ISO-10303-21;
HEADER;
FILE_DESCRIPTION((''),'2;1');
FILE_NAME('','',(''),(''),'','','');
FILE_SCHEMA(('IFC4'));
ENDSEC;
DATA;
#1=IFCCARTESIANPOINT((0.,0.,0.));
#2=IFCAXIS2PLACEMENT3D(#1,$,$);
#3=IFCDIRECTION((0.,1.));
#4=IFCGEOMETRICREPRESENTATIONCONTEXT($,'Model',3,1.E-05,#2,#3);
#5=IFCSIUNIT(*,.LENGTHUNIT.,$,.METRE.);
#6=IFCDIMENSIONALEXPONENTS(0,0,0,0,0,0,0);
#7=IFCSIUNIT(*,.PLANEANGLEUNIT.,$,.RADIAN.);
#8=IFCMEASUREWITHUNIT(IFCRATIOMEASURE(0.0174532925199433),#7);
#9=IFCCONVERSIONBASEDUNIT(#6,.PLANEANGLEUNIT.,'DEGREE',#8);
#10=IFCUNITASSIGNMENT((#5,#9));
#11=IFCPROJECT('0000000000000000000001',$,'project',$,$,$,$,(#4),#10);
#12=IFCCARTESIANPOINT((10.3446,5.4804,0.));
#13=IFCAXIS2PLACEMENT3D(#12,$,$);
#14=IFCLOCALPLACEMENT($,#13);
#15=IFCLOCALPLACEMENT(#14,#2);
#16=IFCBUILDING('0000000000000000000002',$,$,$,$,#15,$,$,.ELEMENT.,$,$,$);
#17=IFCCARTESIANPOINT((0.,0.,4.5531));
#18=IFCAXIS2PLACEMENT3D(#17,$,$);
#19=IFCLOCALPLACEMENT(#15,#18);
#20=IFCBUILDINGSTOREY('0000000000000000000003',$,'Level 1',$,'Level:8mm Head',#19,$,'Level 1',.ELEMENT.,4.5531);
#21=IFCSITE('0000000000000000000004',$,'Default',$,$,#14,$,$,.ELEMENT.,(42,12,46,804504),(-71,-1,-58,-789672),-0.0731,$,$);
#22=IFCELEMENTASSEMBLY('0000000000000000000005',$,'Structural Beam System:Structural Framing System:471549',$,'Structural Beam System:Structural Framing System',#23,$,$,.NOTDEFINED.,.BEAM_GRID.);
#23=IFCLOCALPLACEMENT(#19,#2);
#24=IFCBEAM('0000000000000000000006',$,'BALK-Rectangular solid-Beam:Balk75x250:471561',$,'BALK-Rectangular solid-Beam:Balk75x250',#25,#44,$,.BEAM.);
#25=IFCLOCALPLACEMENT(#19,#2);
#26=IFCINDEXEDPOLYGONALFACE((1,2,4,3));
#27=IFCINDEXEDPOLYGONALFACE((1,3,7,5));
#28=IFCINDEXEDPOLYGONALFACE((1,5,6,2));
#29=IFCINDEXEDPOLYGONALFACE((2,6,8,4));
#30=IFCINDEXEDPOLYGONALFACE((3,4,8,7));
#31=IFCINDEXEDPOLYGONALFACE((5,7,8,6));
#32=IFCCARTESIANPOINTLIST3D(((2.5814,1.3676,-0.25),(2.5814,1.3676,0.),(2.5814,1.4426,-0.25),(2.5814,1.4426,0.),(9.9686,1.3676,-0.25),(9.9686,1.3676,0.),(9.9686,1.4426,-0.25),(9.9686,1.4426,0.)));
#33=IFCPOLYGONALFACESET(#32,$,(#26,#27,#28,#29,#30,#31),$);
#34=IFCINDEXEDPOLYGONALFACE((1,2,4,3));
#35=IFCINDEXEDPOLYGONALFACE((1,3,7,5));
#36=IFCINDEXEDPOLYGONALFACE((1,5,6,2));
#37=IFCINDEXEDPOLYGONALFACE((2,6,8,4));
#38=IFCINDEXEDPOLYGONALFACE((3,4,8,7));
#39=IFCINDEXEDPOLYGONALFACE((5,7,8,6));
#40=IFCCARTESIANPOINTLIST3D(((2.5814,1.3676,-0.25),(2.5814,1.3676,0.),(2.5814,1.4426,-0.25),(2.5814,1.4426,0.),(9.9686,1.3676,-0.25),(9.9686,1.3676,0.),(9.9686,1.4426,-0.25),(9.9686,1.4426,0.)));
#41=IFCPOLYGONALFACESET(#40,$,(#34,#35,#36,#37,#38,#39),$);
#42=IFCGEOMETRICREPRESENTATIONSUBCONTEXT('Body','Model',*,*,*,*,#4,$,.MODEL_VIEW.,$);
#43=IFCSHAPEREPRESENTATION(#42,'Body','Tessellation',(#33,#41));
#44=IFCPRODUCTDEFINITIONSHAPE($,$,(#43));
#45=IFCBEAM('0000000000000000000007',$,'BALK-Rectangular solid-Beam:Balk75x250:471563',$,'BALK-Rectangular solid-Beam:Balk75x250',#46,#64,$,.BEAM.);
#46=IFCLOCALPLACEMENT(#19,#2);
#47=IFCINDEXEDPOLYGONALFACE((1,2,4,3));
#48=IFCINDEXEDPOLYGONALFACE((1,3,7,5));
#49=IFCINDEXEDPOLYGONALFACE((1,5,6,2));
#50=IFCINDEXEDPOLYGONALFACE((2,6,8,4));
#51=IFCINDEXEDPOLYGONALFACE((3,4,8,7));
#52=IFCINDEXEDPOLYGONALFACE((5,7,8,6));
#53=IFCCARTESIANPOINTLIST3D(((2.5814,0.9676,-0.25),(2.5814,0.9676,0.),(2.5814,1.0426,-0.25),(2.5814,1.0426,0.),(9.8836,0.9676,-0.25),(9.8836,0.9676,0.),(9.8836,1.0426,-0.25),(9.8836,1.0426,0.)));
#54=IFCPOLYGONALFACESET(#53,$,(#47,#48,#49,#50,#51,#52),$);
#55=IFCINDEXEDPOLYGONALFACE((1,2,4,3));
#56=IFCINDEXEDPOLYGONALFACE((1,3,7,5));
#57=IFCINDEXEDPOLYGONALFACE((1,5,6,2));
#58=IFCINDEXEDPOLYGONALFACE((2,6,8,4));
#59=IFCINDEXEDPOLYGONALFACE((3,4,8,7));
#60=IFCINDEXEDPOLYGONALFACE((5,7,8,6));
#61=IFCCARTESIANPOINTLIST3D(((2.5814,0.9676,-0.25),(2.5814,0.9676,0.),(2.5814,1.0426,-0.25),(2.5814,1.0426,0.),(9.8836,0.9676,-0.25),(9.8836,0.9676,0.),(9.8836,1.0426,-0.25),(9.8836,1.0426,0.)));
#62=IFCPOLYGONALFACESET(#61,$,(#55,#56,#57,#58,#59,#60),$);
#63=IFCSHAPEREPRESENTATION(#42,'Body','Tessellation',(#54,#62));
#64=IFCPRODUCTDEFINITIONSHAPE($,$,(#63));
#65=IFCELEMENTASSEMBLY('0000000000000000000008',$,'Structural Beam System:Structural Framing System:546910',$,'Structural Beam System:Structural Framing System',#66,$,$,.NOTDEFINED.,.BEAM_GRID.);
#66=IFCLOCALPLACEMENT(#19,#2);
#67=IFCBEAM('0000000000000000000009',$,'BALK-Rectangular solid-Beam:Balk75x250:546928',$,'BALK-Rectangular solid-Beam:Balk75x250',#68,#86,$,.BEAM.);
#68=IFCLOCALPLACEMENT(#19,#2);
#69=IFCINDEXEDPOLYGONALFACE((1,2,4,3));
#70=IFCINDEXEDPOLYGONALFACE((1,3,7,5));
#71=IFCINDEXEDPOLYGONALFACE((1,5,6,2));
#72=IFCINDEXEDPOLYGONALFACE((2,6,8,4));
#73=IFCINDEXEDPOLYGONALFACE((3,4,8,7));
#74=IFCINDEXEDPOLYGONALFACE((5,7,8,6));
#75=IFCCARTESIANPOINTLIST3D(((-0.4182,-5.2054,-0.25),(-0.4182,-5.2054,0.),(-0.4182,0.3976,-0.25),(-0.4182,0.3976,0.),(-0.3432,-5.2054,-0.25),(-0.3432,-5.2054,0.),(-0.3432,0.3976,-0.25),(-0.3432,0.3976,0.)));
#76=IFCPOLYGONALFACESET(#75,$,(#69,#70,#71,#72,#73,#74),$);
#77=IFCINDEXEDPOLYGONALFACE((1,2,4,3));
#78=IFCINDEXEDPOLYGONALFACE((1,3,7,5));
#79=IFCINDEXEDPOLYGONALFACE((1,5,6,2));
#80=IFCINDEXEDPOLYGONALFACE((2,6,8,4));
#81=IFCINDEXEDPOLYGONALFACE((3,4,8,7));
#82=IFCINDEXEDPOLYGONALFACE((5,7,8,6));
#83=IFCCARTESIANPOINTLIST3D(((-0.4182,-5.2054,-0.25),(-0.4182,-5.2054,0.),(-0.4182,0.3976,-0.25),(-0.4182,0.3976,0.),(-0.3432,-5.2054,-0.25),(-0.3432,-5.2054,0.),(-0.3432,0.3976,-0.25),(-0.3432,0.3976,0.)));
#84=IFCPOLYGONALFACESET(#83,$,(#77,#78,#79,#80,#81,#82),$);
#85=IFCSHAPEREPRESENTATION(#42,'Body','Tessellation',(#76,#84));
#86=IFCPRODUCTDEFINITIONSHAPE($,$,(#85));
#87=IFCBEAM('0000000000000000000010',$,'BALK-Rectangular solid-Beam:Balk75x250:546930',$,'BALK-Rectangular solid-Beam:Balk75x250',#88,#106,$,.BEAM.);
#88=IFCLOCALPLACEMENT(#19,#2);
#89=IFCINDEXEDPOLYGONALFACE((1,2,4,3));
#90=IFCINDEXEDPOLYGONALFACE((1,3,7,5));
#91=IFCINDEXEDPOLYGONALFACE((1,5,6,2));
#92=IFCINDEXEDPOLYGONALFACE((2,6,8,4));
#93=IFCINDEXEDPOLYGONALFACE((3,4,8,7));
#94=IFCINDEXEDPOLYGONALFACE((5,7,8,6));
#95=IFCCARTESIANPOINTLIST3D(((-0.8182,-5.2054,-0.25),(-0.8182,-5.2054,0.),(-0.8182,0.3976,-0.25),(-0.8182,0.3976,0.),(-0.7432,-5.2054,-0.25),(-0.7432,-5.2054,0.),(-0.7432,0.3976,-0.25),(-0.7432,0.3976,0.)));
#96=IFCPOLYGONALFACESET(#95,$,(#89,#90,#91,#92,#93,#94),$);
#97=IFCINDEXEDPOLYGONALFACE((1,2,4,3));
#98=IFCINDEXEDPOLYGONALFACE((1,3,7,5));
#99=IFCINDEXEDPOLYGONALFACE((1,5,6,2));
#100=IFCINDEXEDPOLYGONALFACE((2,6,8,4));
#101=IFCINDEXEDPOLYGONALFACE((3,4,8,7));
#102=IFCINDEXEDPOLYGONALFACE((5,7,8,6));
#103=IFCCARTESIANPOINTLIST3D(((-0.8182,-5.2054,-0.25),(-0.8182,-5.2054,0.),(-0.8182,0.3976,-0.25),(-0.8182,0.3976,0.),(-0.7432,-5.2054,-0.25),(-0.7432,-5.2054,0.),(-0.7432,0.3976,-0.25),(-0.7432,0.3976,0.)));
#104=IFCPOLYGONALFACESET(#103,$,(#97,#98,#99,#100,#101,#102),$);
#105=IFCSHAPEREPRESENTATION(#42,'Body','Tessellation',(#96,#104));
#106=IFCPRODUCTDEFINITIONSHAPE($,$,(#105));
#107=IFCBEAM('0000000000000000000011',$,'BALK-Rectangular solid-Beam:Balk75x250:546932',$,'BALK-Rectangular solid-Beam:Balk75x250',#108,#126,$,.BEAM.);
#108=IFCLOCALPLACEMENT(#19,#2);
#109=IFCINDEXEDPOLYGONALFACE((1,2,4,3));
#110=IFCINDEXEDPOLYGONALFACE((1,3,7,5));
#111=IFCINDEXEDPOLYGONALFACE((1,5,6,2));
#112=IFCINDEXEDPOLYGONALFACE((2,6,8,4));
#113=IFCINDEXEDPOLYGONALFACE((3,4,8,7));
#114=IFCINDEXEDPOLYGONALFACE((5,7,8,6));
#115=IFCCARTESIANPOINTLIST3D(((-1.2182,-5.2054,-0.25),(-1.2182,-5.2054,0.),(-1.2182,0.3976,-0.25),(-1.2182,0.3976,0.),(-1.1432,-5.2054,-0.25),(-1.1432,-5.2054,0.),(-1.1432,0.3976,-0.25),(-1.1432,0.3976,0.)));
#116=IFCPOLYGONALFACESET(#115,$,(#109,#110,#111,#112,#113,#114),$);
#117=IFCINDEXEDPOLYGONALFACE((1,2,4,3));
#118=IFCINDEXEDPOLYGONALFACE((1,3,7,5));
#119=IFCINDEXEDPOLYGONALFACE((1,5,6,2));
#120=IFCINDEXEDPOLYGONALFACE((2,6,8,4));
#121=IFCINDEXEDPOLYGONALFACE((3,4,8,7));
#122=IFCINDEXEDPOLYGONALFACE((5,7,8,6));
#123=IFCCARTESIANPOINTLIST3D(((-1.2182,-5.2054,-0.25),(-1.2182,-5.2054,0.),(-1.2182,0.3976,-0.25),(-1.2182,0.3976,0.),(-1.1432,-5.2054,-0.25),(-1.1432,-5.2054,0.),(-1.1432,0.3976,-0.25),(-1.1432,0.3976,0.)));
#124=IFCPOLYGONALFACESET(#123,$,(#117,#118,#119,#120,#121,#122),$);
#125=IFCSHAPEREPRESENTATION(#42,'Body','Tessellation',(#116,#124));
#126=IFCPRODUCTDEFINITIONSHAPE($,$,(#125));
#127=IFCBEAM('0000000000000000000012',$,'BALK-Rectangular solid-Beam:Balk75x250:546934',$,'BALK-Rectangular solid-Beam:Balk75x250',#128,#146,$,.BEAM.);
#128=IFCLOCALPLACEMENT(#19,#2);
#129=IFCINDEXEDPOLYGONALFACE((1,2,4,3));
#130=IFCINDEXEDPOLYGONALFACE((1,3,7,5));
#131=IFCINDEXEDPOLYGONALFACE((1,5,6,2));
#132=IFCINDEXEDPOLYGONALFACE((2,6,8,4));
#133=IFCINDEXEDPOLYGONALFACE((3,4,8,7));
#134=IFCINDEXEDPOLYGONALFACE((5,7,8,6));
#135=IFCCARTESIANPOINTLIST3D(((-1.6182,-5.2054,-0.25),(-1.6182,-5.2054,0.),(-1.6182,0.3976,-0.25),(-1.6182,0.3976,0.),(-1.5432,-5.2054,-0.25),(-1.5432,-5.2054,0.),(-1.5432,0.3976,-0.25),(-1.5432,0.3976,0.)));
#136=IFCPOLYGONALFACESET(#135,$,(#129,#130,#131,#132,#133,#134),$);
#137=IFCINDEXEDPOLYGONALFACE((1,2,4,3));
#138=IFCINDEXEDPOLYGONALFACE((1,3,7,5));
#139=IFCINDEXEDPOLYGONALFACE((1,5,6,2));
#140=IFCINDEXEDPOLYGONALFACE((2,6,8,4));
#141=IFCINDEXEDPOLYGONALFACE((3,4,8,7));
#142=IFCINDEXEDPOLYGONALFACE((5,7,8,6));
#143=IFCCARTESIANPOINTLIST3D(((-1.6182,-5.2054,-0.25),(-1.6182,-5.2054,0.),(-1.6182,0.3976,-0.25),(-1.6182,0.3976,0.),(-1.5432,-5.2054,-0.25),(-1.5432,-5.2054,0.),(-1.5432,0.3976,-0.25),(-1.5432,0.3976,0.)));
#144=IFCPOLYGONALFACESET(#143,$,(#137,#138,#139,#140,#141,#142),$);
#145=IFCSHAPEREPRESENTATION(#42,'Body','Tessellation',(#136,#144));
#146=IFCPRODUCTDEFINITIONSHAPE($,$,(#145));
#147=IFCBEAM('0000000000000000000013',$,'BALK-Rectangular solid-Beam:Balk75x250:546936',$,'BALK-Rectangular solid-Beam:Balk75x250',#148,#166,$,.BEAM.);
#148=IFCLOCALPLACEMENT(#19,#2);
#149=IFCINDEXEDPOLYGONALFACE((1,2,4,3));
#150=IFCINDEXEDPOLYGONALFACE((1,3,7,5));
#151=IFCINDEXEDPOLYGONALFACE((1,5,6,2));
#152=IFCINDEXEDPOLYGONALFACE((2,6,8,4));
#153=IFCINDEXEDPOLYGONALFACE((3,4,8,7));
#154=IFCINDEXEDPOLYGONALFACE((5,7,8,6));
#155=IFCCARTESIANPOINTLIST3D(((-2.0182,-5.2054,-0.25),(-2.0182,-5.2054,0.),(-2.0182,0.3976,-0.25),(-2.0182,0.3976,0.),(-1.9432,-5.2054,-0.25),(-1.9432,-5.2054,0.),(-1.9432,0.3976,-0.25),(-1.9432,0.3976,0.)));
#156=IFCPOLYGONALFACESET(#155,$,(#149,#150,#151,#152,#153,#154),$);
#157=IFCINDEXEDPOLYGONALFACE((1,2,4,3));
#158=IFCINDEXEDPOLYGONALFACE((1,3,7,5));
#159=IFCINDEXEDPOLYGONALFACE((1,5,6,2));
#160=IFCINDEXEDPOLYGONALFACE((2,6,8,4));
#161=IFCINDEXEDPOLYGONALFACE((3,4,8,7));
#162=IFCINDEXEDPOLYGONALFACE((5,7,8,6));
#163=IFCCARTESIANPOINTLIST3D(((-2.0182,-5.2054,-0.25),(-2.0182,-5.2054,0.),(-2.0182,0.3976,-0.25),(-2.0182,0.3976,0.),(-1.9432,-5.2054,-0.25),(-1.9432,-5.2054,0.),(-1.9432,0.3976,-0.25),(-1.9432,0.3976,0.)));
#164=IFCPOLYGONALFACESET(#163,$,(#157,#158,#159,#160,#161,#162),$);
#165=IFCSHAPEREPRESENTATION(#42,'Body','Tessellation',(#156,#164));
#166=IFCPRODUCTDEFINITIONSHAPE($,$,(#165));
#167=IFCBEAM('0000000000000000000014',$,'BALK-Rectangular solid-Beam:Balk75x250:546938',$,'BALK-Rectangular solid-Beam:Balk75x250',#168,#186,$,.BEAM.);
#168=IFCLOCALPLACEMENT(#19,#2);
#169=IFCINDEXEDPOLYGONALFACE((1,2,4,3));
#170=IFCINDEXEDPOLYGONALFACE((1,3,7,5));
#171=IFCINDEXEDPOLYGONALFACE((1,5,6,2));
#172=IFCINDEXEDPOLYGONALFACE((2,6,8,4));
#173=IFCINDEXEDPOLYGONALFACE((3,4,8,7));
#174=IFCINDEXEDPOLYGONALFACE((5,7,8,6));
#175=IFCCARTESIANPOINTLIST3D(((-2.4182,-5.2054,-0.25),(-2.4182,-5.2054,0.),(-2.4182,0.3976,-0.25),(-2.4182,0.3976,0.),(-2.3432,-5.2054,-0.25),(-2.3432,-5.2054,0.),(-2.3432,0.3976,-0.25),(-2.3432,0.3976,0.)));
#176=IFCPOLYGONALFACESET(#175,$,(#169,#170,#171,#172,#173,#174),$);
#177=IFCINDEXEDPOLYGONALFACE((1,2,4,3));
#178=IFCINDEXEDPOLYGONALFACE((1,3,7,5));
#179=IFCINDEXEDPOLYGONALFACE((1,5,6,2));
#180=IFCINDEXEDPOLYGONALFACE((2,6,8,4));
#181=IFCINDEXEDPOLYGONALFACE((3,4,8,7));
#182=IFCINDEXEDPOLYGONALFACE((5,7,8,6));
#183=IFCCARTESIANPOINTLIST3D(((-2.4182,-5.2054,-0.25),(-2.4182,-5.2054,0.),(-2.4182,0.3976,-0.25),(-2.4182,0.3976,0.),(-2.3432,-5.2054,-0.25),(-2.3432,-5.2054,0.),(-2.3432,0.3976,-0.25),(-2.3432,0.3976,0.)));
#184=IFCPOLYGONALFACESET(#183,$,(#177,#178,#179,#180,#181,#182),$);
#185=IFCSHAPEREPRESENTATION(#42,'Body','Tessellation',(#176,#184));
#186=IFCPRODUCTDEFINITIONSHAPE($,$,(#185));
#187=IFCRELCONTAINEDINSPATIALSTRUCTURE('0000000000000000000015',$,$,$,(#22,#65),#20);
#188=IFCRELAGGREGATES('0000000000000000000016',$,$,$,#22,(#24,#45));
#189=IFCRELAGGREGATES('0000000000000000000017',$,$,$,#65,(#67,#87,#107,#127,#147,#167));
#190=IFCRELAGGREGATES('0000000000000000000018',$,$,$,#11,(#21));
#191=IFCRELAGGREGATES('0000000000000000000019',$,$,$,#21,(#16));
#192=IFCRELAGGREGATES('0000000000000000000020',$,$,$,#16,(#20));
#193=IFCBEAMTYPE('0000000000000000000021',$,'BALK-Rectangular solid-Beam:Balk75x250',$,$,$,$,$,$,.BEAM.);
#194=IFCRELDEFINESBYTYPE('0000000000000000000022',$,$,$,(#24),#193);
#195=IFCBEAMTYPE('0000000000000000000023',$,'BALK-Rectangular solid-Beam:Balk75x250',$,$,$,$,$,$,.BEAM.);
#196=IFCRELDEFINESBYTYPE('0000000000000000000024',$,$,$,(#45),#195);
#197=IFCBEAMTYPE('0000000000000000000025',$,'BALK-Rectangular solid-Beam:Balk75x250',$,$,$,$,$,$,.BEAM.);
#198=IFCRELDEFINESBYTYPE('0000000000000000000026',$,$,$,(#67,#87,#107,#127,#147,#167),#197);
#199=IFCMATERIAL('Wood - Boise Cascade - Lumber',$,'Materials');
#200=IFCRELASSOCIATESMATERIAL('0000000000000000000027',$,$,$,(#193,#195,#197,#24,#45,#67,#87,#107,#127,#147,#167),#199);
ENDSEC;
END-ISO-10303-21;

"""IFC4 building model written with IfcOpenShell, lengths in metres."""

from ifc_helpers import new_model, entity, si_unit, converted_unit, direction, frame, frame_2d, origin, origin_2d_with_axis, place, context, subcontext, project, spatial, rectangle, extrude, source, transform, mapped, material, material_profile, profile_set, profile_usage, type_object, type_shapes, element, aggregate, save


model = new_model("IFC4")

# Units and contexts
model_context = context("Model", 3, precision=1e-05, world=origin(), true_north=direction((0.0, 1.0)))
body_context = subcontext(model_context, "Body", "Model", "MODEL_VIEW")
ifc_project = project(units=[si_unit("LENGTHUNIT", "METRE"), converted_unit("PLANEANGLEUNIT", "DEGREE", entity("IfcRatioMeasure", 0.0174532925199433), si_unit("PLANEANGLEUNIT", "RADIAN"), dimensions=[0, 0, 0, 0, 0, 0, 0])], contexts=[model_context])

# Site, building, storey
site_placement = place(None, frame((10.3446, 5.4804, 0.0)))
site = spatial("IfcSite", under=ifc_project, at=site_placement, Name="Default", CompositionType="ELEMENT", RefLatitude=(42, 12, 46, 804504), RefLongitude=(-71, -1, -58, -789672), RefElevation=-0.0731)
building_placement = place(site_placement, origin())
building = spatial("IfcBuilding", under=site, at=building_placement, CompositionType="ELEMENT")
storey_placement = place(building_placement, frame((0.0, 0.0, 4.5531)))
storey = spatial("IfcBuildingStorey", under=building, at=storey_placement, Name="Level 1", ObjectType="Level:8mm Head", LongName="Level 1", CompositionType="ELEMENT", Elevation=4.5531)

# Element assemblies, beams
ifc_material = material(Name="Wood - Boise Cascade - Lumber", Category="Materials")
ifc_material_profile = material_profile(ifc_material, rectangle(XDim=0.25, YDim=0.075, at=frame_2d((0.0, 0.0), x_axis=(1.0, 0.0))), Name="Balk75x250")
ifc_profile_set = profile_set([ifc_material_profile], Name="Balk75x250")
assembly_1_placement = place(storey_placement, origin())
assembly_1 = element("IfcElementAssembly", 1, at=assembly_1_placement, inside=storey, Name="Structural Beam System:Structural Framing System:471549", ObjectType="Structural Beam System:Structural Framing System", AssemblyPlace="NOTDEFINED", PredefinedType="BEAM_GRID")
ifc_profile_usage_1 = profile_usage(ifc_profile_set, cardinal=8)
beam_type_1 = type_object("IfcBeamType", Name="BALK-Rectangular solid-Beam:Balk75x250", PredefinedType="BEAM", material=ifc_profile_set)
shared_shape_1 = source(origin(), body_context, "Body", "SweptSolid", [
    extrude(rectangle(XDim=0.25, YDim=0.075, at=frame_2d((0.0, 0.0), x_axis=(1.0, 0.0))), frame((2.5814, 1.4051, 4.4281), z_axis=(1.0, 0.0, 0.0), x_axis=(0.0, 0.0, -1.0)), (0.0, 0.0, 1.0), 7.3872),
    extrude(rectangle(XDim=0.25, YDim=0.075, at=frame_2d((0.0, 0.0), x_axis=(1.0, 0.0))), frame((2.5814, 1.4051, 4.4281), z_axis=(1.0, 0.0, 0.0), x_axis=(0.0, 0.0, -1.0)), (0.0, 0.0, 1.0), 7.3872),
])
type_shapes(beam_type_1, [shared_shape_1])
beam_1_placement = place(assembly_1_placement, frame((0.0, 0.0, -4.5531)))
beam_1 = element("IfcBeam", 2, at=beam_1_placement, type_object=beam_type_1, material=ifc_profile_usage_1, Name="BALK-Rectangular solid-Beam:Balk75x250:471561", ObjectType="BALK-Rectangular solid-Beam:Balk75x250", PredefinedType="BEAM", context=body_context, shape_type="MappedRepresentation", body=[
    mapped(shared_shape_1, transform((0.0, 0.0, 0.0), scale=1.0)),
])
ifc_profile_usage_2 = profile_usage(ifc_profile_set, cardinal=8)
beam_type_2 = type_object("IfcBeamType", Name="BALK-Rectangular solid-Beam:Balk75x250", PredefinedType="BEAM", material=ifc_profile_set)
shared_shape_2 = source(origin(), body_context, "Body", "SweptSolid", [
    extrude(rectangle(XDim=0.25, YDim=0.075, at=frame_2d((0.0, 0.0), x_axis=(1.0, 0.0))), frame((2.5814, 1.0051, 4.4281), z_axis=(1.0, 0.0, 0.0), x_axis=(0.0, 0.0, -1.0)), (0.0, 0.0, 1.0), 7.3022),
    extrude(rectangle(XDim=0.25, YDim=0.075, at=frame_2d((0.0, 0.0), x_axis=(1.0, 0.0))), frame((2.5814, 1.0051, 4.4281), z_axis=(1.0, 0.0, 0.0), x_axis=(0.0, 0.0, -1.0)), (0.0, 0.0, 1.0), 7.3022),
])
type_shapes(beam_type_2, [shared_shape_2])
beam_2_placement = place(assembly_1_placement, frame((0.0, 0.0, -4.5531)))
beam_2 = element("IfcBeam", 3, at=beam_2_placement, type_object=beam_type_2, material=ifc_profile_usage_2, Name="BALK-Rectangular solid-Beam:Balk75x250:471563", ObjectType="BALK-Rectangular solid-Beam:Balk75x250", PredefinedType="BEAM", context=body_context, shape_type="MappedRepresentation", body=[
    mapped(shared_shape_2, transform((0.0, 0.0, 0.0), scale=1.0)),
])
aggregate(assembly_1, [beam_1, beam_2])
assembly_2_placement = place(storey_placement, origin())
assembly_2 = element("IfcElementAssembly", 4, at=assembly_2_placement, inside=storey, Name="Structural Beam System:Structural Framing System:546910", ObjectType="Structural Beam System:Structural Framing System", AssemblyPlace="NOTDEFINED", PredefinedType="BEAM_GRID")
ifc_profile_usage_3 = profile_usage(ifc_profile_set, cardinal=8)
beam_type_3 = type_object("IfcBeamType", Name="BALK-Rectangular solid-Beam:Balk75x250", PredefinedType="BEAM", material=ifc_profile_set)
shared_shape_3 = source(origin(), body_context, "Body", "SweptSolid", [
    extrude(rectangle(XDim=0.25, YDim=0.075, at=origin_2d_with_axis()), frame((-2.9078, 0.0, 0.0), z_axis=(1.0, 0.0, 0.0), x_axis=(0.0, 0.0, -1.0)), (0.0, 0.0, 1.0), 5.603),
    extrude(rectangle(XDim=0.25, YDim=0.075, at=origin_2d_with_axis()), frame((-2.9078, 0.0, 0.0), z_axis=(1.0, 0.0, 0.0), x_axis=(0.0, 0.0, -1.0)), (0.0, 0.0, 1.0), 5.603),
])
type_shapes(beam_type_3, [shared_shape_3])
beam_3_placement = place(assembly_2_placement, frame((-0.3807, -2.5102, -0.125), z_axis=(0.0, 0.0, 1.0), x_axis=(0.0, -1.0, 0.0)))
beam_3 = element("IfcBeam", 5, at=beam_3_placement, type_object=beam_type_3, material=ifc_profile_usage_3, Name="BALK-Rectangular solid-Beam:Balk75x250:546928", ObjectType="BALK-Rectangular solid-Beam:Balk75x250", PredefinedType="BEAM", context=body_context, shape_type="MappedRepresentation", body=[
    mapped(shared_shape_3, transform((0.0, 0.0, 0.0), scale=1.0)),
])
ifc_profile_usage_4 = profile_usage(ifc_profile_set, cardinal=8)
beam_4_placement = place(assembly_2_placement, frame((-0.7807, -2.5102, -0.125), z_axis=(0.0, 0.0, 1.0), x_axis=(0.0, -1.0, 0.0)))
beam_4 = element("IfcBeam", 6, at=beam_4_placement, type_object=beam_type_3, material=ifc_profile_usage_4, Name="BALK-Rectangular solid-Beam:Balk75x250:546930", ObjectType="BALK-Rectangular solid-Beam:Balk75x250", PredefinedType="BEAM", context=body_context, shape_type="MappedRepresentation", body=[
    mapped(shared_shape_3, transform((0.0, 0.0, 0.0), scale=1.0)),
])
ifc_profile_usage_5 = profile_usage(ifc_profile_set, cardinal=8)
beam_5_placement = place(assembly_2_placement, frame((-1.1807, -2.5102, -0.125), z_axis=(0.0, 0.0, 1.0), x_axis=(0.0, -1.0, 0.0)))
beam_5 = element("IfcBeam", 7, at=beam_5_placement, type_object=beam_type_3, material=ifc_profile_usage_5, Name="BALK-Rectangular solid-Beam:Balk75x250:546932", ObjectType="BALK-Rectangular solid-Beam:Balk75x250", PredefinedType="BEAM", context=body_context, shape_type="MappedRepresentation", body=[
    mapped(shared_shape_3, transform((0.0, 0.0, 0.0), scale=1.0)),
])
ifc_profile_usage_6 = profile_usage(ifc_profile_set, cardinal=8)
beam_6_placement = place(assembly_2_placement, frame((-1.5807, -2.5102, -0.125), z_axis=(0.0, 0.0, 1.0), x_axis=(0.0, -1.0, 0.0)))
beam_6 = element("IfcBeam", 8, at=beam_6_placement, type_object=beam_type_3, material=ifc_profile_usage_6, Name="BALK-Rectangular solid-Beam:Balk75x250:546934", ObjectType="BALK-Rectangular solid-Beam:Balk75x250", PredefinedType="BEAM", context=body_context, shape_type="MappedRepresentation", body=[
    mapped(shared_shape_3, transform((0.0, 0.0, 0.0), scale=1.0)),
])
ifc_profile_usage_7 = profile_usage(ifc_profile_set, cardinal=8)
beam_7_placement = place(assembly_2_placement, frame((-1.9807, -2.5102, -0.125), z_axis=(0.0, 0.0, 1.0), x_axis=(0.0, -1.0, 0.0)))
beam_7 = element("IfcBeam", 9, at=beam_7_placement, type_object=beam_type_3, material=ifc_profile_usage_7, Name="BALK-Rectangular solid-Beam:Balk75x250:546936", ObjectType="BALK-Rectangular solid-Beam:Balk75x250", PredefinedType="BEAM", context=body_context, shape_type="MappedRepresentation", body=[
    mapped(shared_shape_3, transform((0.0, 0.0, 0.0), scale=1.0)),
])
ifc_profile_usage_8 = profile_usage(ifc_profile_set, cardinal=8)
beam_8_placement = place(assembly_2_placement, frame((-2.3807, -2.5102, -0.125), z_axis=(0.0, 0.0, 1.0), x_axis=(0.0, -1.0, 0.0)))
beam_8 = element("IfcBeam", 10, at=beam_8_placement, type_object=beam_type_3, material=ifc_profile_usage_8, Name="BALK-Rectangular solid-Beam:Balk75x250:546938", ObjectType="BALK-Rectangular solid-Beam:Balk75x250", PredefinedType="BEAM", context=body_context, shape_type="MappedRepresentation", body=[
    mapped(shared_shape_3, transform((0.0, 0.0, 0.0), scale=1.0)),
])
aggregate(assembly_2, [beam_3, beam_4, beam_5, beam_6, beam_7, beam_8])

save(model, "model.ifc")
